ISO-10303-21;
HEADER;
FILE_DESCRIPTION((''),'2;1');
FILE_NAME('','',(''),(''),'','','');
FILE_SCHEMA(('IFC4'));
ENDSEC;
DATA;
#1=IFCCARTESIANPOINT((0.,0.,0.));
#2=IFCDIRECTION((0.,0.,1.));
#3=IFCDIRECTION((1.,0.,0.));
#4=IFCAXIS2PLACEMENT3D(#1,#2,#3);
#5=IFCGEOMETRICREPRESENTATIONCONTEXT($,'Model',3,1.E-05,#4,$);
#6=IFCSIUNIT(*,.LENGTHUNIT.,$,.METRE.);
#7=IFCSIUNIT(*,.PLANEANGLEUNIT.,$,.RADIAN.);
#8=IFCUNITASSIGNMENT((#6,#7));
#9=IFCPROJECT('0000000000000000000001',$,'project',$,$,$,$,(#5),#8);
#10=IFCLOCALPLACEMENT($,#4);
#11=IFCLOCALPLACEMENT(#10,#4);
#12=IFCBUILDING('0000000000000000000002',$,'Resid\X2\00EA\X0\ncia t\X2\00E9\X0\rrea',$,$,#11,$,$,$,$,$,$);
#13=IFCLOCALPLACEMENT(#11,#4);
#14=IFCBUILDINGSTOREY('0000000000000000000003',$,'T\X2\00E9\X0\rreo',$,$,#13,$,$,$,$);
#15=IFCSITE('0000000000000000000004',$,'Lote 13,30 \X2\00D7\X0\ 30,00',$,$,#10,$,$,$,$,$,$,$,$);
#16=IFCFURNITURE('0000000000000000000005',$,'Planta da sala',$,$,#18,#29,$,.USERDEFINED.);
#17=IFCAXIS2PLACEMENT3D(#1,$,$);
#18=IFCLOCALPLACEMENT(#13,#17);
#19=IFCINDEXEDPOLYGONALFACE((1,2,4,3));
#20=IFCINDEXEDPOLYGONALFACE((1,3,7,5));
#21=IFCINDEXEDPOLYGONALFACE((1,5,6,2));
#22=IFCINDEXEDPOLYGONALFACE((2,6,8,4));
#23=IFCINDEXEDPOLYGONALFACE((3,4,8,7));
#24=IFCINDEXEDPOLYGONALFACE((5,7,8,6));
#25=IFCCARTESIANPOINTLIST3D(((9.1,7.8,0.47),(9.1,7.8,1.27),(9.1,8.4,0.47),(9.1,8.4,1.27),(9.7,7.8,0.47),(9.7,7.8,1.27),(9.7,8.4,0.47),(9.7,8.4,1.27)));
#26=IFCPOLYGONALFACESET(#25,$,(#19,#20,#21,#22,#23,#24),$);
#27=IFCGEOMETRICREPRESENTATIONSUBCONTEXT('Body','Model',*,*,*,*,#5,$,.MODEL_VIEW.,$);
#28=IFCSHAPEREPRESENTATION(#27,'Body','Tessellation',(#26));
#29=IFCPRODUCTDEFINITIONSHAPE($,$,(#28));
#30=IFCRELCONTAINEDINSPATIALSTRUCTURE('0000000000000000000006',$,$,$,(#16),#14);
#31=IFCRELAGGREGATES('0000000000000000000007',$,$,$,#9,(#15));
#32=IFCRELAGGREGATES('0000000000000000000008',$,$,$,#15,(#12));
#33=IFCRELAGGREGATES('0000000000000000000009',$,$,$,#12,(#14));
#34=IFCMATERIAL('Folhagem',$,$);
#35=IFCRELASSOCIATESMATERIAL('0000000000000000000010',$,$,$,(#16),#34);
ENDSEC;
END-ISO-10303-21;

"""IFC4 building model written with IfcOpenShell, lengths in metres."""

from ifc_helpers import new_model, si_unit, frame, origin_with_axes, place, context, subcontext, project, spatial, line, indexed_curve, outline, extrude, material, element, save


model = new_model("IFC4")

# Units and contexts
model_context = context("Model", 3, precision=1e-05, world=origin_with_axes())
body_context = subcontext(model_context, "Body", "Model", "MODEL_VIEW")
ifc_project = project(units=[si_unit("LENGTHUNIT", "METRE"), si_unit("PLANEANGLEUNIT", "RADIAN")], contexts=[model_context])

# Site, building, storey
site_placement = place(None, origin_with_axes())
site = spatial("IfcSite", under=ifc_project, at=site_placement, Name="Lote 13,30 × 30,00")
building_placement = place(site_placement, origin_with_axes())
building = spatial("IfcBuilding", under=site, at=building_placement, Name="Residência térrea")
storey_placement = place(building_placement, origin_with_axes())
storey = spatial("IfcBuildingStorey", under=building, at=storey_placement, Name="Térreo")

# Furniture
ifc_material_1 = material(Name="Folhagem")
furniture_1_placement = place(storey_placement, frame((9.1, 7.8, 0.47), z_axis=(0.0, 0.0, 1.0), x_axis=(1.0, 0.0, 0.0)))
element("IfcFurniture", 1, at=furniture_1_placement, inside=storey, material=ifc_material_1, Name="Planta da sala", PredefinedType="USERDEFINED", context=body_context, shape_type="SweptSolid", body=[
    extrude(outline(indexed_curve([(0.0, 0.0), (0.6, 0.0), (0.6, 0.6), (0.0, 0.6)], segments=[line(1, 2, 3, 4, 1)])), origin_with_axes(), (0.0, 0.0, 1.0), 0.8),
])

save(model, "model.ifc")
